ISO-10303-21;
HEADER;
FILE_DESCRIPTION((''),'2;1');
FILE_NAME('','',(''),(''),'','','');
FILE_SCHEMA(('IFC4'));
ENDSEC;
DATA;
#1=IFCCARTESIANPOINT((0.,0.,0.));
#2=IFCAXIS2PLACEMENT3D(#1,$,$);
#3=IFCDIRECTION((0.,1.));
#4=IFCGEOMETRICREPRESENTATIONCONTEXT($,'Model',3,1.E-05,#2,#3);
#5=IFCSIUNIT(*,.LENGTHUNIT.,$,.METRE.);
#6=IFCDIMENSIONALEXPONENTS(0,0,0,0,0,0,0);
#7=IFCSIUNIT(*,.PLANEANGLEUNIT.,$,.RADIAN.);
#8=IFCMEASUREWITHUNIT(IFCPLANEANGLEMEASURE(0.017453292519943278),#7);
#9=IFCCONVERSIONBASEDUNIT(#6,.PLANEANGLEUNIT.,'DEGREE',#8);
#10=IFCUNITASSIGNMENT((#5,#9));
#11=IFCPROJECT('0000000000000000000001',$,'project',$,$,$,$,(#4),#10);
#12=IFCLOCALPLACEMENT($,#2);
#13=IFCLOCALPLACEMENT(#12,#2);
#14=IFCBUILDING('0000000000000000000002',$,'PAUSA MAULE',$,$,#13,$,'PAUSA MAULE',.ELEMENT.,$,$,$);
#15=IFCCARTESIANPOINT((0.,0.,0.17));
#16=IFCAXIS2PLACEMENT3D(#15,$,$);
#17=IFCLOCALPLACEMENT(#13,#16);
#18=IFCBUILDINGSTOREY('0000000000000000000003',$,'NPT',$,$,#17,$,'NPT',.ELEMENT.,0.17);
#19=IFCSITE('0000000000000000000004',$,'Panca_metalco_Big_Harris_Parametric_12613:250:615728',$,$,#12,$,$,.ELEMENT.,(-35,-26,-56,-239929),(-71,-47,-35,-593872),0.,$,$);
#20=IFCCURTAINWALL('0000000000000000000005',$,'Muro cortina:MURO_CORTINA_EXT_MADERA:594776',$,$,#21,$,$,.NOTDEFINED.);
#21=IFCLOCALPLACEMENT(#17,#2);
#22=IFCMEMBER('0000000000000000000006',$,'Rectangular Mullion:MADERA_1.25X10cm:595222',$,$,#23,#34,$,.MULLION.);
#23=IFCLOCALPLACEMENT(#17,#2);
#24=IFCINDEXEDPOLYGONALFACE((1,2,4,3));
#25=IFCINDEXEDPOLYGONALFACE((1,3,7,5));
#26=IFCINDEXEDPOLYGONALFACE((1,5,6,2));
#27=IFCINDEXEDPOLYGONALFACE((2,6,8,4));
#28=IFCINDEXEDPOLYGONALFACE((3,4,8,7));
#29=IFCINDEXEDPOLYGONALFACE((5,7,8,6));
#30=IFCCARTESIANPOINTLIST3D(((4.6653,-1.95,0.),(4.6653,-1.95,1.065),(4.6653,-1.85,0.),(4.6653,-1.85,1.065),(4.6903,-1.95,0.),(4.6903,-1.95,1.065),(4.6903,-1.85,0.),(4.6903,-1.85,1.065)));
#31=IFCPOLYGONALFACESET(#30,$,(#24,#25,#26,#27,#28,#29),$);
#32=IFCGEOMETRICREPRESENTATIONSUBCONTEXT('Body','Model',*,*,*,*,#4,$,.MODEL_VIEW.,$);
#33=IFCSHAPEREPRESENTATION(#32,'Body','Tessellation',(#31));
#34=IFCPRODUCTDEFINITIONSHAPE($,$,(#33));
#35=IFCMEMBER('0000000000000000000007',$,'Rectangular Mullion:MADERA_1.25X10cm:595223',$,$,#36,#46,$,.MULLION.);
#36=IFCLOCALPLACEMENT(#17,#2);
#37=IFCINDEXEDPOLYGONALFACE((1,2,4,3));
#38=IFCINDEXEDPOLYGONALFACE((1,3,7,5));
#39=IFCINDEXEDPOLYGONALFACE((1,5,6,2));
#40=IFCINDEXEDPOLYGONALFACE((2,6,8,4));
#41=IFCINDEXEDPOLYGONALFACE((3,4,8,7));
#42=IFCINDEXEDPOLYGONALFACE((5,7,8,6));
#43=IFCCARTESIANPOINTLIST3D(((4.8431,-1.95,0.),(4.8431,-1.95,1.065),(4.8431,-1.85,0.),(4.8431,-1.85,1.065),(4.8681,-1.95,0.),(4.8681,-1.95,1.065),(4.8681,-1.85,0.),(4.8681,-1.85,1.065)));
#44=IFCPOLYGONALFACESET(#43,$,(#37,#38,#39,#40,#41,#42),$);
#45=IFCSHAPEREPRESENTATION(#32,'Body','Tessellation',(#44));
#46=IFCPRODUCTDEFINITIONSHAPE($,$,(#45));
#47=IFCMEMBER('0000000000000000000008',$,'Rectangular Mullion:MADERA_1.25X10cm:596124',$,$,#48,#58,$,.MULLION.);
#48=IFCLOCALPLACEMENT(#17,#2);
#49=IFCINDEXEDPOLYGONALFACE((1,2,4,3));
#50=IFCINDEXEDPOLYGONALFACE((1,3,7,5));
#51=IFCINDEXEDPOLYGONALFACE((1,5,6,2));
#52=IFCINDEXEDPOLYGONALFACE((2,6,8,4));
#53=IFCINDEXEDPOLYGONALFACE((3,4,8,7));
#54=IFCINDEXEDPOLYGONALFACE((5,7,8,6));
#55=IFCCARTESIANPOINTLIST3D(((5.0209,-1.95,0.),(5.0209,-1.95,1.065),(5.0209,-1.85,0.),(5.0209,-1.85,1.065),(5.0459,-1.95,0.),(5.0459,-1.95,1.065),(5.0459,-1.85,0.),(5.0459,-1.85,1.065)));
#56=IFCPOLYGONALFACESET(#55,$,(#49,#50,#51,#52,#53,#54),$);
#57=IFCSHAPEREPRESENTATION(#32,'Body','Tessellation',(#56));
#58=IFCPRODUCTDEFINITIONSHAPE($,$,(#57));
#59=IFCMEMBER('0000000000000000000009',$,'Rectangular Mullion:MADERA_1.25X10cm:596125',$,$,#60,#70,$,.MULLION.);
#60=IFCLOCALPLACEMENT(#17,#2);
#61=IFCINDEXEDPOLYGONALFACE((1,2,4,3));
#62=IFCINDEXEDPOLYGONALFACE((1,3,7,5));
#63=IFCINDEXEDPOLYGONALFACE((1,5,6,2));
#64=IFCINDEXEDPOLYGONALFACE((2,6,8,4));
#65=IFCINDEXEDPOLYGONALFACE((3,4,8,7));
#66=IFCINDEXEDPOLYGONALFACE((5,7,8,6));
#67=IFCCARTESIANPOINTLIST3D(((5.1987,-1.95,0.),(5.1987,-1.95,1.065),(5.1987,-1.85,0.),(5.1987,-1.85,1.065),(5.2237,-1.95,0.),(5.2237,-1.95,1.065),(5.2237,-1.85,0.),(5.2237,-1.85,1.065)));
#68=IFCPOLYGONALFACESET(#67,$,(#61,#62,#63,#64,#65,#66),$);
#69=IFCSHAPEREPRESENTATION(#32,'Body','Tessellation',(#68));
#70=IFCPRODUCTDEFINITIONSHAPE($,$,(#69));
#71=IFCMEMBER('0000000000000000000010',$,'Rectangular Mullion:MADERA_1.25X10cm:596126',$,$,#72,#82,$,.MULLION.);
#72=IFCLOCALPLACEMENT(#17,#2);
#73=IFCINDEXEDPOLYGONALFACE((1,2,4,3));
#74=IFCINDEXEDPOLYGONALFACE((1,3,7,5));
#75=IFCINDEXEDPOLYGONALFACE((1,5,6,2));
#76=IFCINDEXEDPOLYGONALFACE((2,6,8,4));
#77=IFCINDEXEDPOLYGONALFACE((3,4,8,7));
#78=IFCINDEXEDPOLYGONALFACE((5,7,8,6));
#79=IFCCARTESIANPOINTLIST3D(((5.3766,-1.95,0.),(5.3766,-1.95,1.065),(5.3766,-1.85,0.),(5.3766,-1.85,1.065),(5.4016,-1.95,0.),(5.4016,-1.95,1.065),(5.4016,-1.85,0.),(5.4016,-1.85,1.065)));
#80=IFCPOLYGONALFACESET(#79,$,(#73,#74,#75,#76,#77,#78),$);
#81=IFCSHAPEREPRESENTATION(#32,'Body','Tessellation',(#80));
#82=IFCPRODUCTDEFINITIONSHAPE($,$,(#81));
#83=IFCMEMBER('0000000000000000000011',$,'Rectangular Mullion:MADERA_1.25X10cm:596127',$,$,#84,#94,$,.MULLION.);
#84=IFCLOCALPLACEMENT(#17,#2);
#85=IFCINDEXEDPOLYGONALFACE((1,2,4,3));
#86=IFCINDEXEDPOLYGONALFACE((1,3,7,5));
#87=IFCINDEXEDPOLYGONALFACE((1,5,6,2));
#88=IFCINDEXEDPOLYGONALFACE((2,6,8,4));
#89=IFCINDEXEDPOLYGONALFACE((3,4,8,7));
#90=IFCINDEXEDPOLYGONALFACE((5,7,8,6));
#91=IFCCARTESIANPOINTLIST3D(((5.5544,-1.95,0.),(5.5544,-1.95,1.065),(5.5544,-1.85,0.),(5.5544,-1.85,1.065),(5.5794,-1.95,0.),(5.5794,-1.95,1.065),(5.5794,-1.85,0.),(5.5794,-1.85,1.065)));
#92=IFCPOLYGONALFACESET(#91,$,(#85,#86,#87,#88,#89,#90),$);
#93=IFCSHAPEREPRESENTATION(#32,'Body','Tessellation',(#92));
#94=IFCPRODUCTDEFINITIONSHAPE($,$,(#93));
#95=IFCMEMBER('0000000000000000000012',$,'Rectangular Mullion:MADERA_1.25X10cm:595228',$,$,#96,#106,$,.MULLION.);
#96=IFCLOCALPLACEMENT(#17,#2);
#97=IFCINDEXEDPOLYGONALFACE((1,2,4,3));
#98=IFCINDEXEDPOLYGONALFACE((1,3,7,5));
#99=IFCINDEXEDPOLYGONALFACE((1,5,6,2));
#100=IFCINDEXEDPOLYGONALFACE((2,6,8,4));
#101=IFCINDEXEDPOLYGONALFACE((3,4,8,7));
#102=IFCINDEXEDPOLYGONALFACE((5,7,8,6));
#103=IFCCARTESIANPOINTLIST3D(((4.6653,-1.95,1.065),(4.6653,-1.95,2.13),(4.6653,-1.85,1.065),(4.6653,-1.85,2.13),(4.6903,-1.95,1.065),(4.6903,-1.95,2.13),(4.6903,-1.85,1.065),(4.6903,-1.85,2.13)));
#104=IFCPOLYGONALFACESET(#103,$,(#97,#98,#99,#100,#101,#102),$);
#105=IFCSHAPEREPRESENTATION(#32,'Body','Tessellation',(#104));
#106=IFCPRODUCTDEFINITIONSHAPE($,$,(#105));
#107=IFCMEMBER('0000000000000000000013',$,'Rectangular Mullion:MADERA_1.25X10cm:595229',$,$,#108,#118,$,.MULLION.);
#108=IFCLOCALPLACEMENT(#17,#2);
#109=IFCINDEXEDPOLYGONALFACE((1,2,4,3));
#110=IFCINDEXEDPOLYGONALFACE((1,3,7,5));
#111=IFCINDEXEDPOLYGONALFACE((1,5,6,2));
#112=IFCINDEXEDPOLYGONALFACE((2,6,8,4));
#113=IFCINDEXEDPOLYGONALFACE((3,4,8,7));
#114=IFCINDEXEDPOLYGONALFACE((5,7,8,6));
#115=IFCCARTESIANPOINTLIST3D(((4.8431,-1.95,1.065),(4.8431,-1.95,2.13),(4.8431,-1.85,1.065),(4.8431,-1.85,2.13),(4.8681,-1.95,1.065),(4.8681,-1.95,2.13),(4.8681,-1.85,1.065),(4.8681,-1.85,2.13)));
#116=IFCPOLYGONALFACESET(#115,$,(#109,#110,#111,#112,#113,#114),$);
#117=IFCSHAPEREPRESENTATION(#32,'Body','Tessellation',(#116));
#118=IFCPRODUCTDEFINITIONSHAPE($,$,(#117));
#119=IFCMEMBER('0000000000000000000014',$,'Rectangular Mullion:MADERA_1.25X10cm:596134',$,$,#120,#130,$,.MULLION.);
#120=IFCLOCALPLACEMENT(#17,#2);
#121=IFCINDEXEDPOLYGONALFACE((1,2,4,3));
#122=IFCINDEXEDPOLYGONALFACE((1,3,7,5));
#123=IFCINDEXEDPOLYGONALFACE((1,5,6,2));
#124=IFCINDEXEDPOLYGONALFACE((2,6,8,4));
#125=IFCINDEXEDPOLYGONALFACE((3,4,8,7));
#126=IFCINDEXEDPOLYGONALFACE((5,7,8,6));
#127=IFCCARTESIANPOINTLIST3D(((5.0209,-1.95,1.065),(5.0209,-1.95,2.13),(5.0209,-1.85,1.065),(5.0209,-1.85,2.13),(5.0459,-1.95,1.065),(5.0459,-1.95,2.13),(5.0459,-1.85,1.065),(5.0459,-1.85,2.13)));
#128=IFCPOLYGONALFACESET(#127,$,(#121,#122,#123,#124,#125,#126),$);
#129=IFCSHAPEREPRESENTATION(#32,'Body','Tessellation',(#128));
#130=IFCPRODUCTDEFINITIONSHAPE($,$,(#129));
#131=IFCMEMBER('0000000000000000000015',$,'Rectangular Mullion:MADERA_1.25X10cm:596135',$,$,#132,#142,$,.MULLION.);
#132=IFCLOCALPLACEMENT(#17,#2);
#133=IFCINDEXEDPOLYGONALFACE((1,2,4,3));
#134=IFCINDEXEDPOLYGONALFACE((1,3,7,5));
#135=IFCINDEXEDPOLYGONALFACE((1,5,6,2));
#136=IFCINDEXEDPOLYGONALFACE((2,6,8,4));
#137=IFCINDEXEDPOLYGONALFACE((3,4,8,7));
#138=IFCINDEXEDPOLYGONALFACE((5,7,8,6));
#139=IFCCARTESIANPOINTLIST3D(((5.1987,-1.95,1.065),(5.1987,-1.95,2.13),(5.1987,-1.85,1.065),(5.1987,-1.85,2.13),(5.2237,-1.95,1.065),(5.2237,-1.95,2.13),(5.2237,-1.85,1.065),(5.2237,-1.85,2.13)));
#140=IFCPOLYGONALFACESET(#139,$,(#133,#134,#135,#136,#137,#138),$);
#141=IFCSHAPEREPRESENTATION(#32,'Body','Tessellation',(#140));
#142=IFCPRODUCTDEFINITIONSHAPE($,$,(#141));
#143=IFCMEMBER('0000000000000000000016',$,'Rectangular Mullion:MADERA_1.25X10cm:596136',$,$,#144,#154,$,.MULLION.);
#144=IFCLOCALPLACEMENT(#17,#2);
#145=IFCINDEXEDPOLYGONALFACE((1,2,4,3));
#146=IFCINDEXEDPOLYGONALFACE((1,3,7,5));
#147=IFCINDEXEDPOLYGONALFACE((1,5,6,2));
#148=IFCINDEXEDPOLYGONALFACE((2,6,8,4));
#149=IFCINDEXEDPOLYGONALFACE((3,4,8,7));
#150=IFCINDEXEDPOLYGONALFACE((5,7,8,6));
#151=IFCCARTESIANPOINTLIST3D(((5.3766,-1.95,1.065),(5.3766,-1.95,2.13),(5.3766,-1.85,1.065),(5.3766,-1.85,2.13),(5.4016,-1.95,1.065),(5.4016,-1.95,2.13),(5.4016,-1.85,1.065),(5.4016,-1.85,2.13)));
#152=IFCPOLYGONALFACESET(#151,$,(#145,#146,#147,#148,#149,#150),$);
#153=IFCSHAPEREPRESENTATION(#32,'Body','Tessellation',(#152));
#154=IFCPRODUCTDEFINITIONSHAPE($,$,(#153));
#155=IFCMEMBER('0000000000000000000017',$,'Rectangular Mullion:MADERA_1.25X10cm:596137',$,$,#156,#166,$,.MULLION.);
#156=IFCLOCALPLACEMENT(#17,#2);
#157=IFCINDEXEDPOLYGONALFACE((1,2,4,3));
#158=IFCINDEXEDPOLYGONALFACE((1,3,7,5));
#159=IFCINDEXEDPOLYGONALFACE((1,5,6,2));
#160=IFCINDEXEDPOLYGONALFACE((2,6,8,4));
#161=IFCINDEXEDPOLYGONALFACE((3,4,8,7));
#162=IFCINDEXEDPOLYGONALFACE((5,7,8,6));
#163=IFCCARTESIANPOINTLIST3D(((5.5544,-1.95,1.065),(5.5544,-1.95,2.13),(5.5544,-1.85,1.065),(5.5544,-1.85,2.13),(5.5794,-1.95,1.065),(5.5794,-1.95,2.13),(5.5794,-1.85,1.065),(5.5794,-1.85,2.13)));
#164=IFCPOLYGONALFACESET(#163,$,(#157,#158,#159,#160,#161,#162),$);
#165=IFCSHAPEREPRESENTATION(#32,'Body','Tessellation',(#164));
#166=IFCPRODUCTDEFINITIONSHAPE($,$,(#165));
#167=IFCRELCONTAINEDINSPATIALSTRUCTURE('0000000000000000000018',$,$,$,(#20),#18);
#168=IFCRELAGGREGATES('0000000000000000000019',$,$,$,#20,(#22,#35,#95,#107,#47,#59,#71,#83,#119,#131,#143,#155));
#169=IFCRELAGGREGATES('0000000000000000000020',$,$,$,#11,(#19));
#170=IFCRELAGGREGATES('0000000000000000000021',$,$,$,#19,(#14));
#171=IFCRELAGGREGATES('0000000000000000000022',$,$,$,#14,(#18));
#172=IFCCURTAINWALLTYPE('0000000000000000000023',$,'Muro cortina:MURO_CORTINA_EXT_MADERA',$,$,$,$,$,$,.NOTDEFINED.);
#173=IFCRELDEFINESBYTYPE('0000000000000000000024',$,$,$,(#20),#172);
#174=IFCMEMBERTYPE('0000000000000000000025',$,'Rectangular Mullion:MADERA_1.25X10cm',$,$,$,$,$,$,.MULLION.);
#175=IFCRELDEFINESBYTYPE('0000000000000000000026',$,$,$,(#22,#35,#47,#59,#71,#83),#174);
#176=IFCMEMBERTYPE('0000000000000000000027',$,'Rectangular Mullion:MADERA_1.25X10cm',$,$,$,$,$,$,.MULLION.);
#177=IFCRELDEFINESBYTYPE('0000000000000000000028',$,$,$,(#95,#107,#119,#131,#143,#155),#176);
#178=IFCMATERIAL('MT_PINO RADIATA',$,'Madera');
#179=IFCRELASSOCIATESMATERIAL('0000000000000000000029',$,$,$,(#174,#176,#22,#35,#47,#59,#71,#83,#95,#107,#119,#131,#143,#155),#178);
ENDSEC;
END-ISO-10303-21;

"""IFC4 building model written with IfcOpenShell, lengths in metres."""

from ifc_helpers import new_model, entity, si_unit, converted_unit, direction, frame, frame_2d, origin, place, context, subcontext, project, spatial, rectangle, extrude, source, transform, mapped, material, material_profile, profile_set, profile_usage, type_object, type_shapes, element, aggregate, save


model = new_model("IFC4")

# Units and contexts
model_context = context("Model", 3, precision=1e-05, world=origin(), true_north=direction((0.0, 1.0)))
body_context = subcontext(model_context, "Body", "Model", "MODEL_VIEW")
ifc_project = project(units=[si_unit("LENGTHUNIT", "METRE"), converted_unit("PLANEANGLEUNIT", "DEGREE", entity("IfcPlaneAngleMeasure", 0.017453292519943278), si_unit("PLANEANGLEUNIT", "RADIAN"), dimensions=[0, 0, 0, 0, 0, 0, 0])], contexts=[model_context])

# Site, building, storey
site_placement = place(None, origin())
site = spatial("IfcSite", under=ifc_project, at=site_placement, Name="Panca_metalco_Big_Harris_Parametric_12613:250:615728", CompositionType="ELEMENT", RefLatitude=(-35, -26, -56, -239929), RefLongitude=(-71, -47, -35, -593872), RefElevation=0.0)
building_placement = place(site_placement, origin())
building = spatial("IfcBuilding", under=site, at=building_placement, Name="PAUSA MAULE", LongName="PAUSA MAULE", CompositionType="ELEMENT")
storey_placement = place(building_placement, frame((0.0, 0.0, 0.17)))
storey = spatial("IfcBuildingStorey", under=building, at=storey_placement, Name="NPT", LongName="NPT", CompositionType="ELEMENT", Elevation=0.17)

# Curtain wall, members
curtain_wall_type = type_object("IfcCurtainWallType", Name="Muro cortina:MURO_CORTINA_EXT_MADERA", PredefinedType="NOTDEFINED")
curtain_wall_placement = place(storey_placement, frame((0.0, 0.0, -0.17)))
curtain_wall = element("IfcCurtainWall", 1, at=curtain_wall_placement, inside=storey, type_object=curtain_wall_type, Name="Muro cortina:MURO_CORTINA_EXT_MADERA:594776", PredefinedType="NOTDEFINED")
ifc_material = material(Name="MT_PINO RADIATA", Category="Madera")
ifc_material_profile = material_profile(ifc_material, rectangle(XDim=0.025, YDim=0.1, at=frame_2d((0.0, 0.0), x_axis=(1.0, 0.0))), Name="MADERA_1.25X10cm")
ifc_profile_set = profile_set([ifc_material_profile], Name="MADERA_1.25X10cm")
ifc_profile_usage = profile_usage(ifc_profile_set)
member_type_1 = type_object("IfcMemberType", Name="Rectangular Mullion:MADERA_1.25X10cm", PredefinedType="MULLION", material=ifc_profile_set)
shared_shape_1 = source(origin(), body_context, "Body", "SweptSolid", [
    extrude(rectangle(XDim=0.025, YDim=0.1, at=frame_2d((0.0, 0.0), x_axis=(1.0, 0.0))), frame((0.0, 0.0, -1.065), z_axis=(0.0, 0.0, 1.0), x_axis=(-1.0, 0.0, 0.0)), (0.0, 0.0, 1.0), 1.065),
])
type_shapes(member_type_1, [shared_shape_1])
member_1_placement = place(curtain_wall_placement, frame((4.6778, -1.9, 0.17), z_axis=(0.0, 0.0, -1.0), x_axis=(1.0, 0.0, 0.0)))
member_1 = element("IfcMember", 2, at=member_1_placement, type_object=member_type_1, material=ifc_profile_usage, Name="Rectangular Mullion:MADERA_1.25X10cm:595222", PredefinedType="MULLION", context=body_context, shape_type="MappedRepresentation", body=[
    mapped(shared_shape_1, transform((0.0, 0.0, 0.0), scale=1.0)),
])
member_2_placement = place(curtain_wall_placement, frame((4.8556, -1.9, 0.17), z_axis=(0.0, 0.0, -1.0), x_axis=(1.0, 0.0, 0.0)))
member_2 = element("IfcMember", 3, at=member_2_placement, type_object=member_type_1, material=ifc_profile_usage, Name="Rectangular Mullion:MADERA_1.25X10cm:595223", PredefinedType="MULLION", context=body_context, shape_type="MappedRepresentation", body=[
    mapped(shared_shape_1, transform((0.0, 0.0, 0.0), scale=1.0)),
])
member_3_placement = place(curtain_wall_placement, frame((5.0334, -1.9, 0.17), z_axis=(0.0, 0.0, -1.0), x_axis=(1.0, 0.0, 0.0)))
member_3 = element("IfcMember", 4, at=member_3_placement, type_object=member_type_1, material=ifc_profile_usage, Name="Rectangular Mullion:MADERA_1.25X10cm:596124", PredefinedType="MULLION", context=body_context, shape_type="MappedRepresentation", body=[
    mapped(shared_shape_1, transform((0.0, 0.0, 0.0), scale=1.0)),
])
member_4_placement = place(curtain_wall_placement, frame((5.2112, -1.9, 0.17), z_axis=(0.0, 0.0, -1.0), x_axis=(1.0, 0.0, 0.0)))
member_4 = element("IfcMember", 5, at=member_4_placement, type_object=member_type_1, material=ifc_profile_usage, Name="Rectangular Mullion:MADERA_1.25X10cm:596125", PredefinedType="MULLION", context=body_context, shape_type="MappedRepresentation", body=[
    mapped(shared_shape_1, transform((0.0, 0.0, 0.0), scale=1.0)),
])
member_5_placement = place(curtain_wall_placement, frame((5.3891, -1.9, 0.17), z_axis=(0.0, 0.0, -1.0), x_axis=(1.0, 0.0, 0.0)))
member_5 = element("IfcMember", 6, at=member_5_placement, type_object=member_type_1, material=ifc_profile_usage, Name="Rectangular Mullion:MADERA_1.25X10cm:596126", PredefinedType="MULLION", context=body_context, shape_type="MappedRepresentation", body=[
    mapped(shared_shape_1, transform((0.0, 0.0, 0.0), scale=1.0)),
])
member_6_placement = place(curtain_wall_placement, frame((5.5669, -1.9, 0.17), z_axis=(0.0, 0.0, -1.0), x_axis=(1.0, 0.0, 0.0)))
member_6 = element("IfcMember", 7, at=member_6_placement, type_object=member_type_1, material=ifc_profile_usage, Name="Rectangular Mullion:MADERA_1.25X10cm:596127", PredefinedType="MULLION", context=body_context, shape_type="MappedRepresentation", body=[
    mapped(shared_shape_1, transform((0.0, 0.0, 0.0), scale=1.0)),
])
member_type_2 = type_object("IfcMemberType", Name="Rectangular Mullion:MADERA_1.25X10cm", PredefinedType="MULLION", material=ifc_profile_set)
shared_shape_2 = source(origin(), body_context, "Body", "SweptSolid", [
    extrude(rectangle(XDim=0.025, YDim=0.1, at=frame_2d((0.0, 0.0), x_axis=(1.0, 0.0))), frame((0.0, 0.0, -1.065), z_axis=(0.0, 0.0, 1.0), x_axis=(-1.0, 0.0, 0.0)), (0.0, 0.0, 1.0), 1.065),
])
type_shapes(member_type_2, [shared_shape_2])
member_7_placement = place(curtain_wall_placement, frame((4.6778, -1.9, 1.235), z_axis=(0.0, 0.0, -1.0), x_axis=(1.0, 0.0, 0.0)))
member_7 = element("IfcMember", 8, at=member_7_placement, type_object=member_type_2, material=ifc_profile_usage, Name="Rectangular Mullion:MADERA_1.25X10cm:595228", PredefinedType="MULLION", context=body_context, shape_type="MappedRepresentation", body=[
    mapped(shared_shape_2, transform((0.0, 0.0, 0.0), scale=1.0)),
])
member_8_placement = place(curtain_wall_placement, frame((4.8556, -1.9, 1.235), z_axis=(0.0, 0.0, -1.0), x_axis=(1.0, 0.0, 0.0)))
member_8 = element("IfcMember", 9, at=member_8_placement, type_object=member_type_2, material=ifc_profile_usage, Name="Rectangular Mullion:MADERA_1.25X10cm:595229", PredefinedType="MULLION", context=body_context, shape_type="MappedRepresentation", body=[
    mapped(shared_shape_2, transform((0.0, 0.0, 0.0), scale=1.0)),
])
member_9_placement = place(curtain_wall_placement, frame((5.0334, -1.9, 1.235), z_axis=(0.0, 0.0, -1.0), x_axis=(1.0, 0.0, 0.0)))
member_9 = element("IfcMember", 10, at=member_9_placement, type_object=member_type_2, material=ifc_profile_usage, Name="Rectangular Mullion:MADERA_1.25X10cm:596134", PredefinedType="MULLION", context=body_context, shape_type="MappedRepresentation", body=[
    mapped(shared_shape_2, transform((0.0, 0.0, 0.0), scale=1.0)),
])
member_10_placement = place(curtain_wall_placement, frame((5.2112, -1.9, 1.235), z_axis=(0.0, 0.0, -1.0), x_axis=(1.0, 0.0, 0.0)))
member_10 = element("IfcMember", 11, at=member_10_placement, type_object=member_type_2, material=ifc_profile_usage, Name="Rectangular Mullion:MADERA_1.25X10cm:596135", PredefinedType="MULLION", context=body_context, shape_type="MappedRepresentation", body=[
    mapped(shared_shape_2, transform((0.0, 0.0, 0.0), scale=1.0)),
])
member_11_placement = place(curtain_wall_placement, frame((5.3891, -1.9, 1.235), z_axis=(0.0, 0.0, -1.0), x_axis=(1.0, 0.0, 0.0)))
member_11 = element("IfcMember", 12, at=member_11_placement, type_object=member_type_2, material=ifc_profile_usage, Name="Rectangular Mullion:MADERA_1.25X10cm:596136", PredefinedType="MULLION", context=body_context, shape_type="MappedRepresentation", body=[
    mapped(shared_shape_2, transform((0.0, 0.0, 0.0), scale=1.0)),
])
member_12_placement = place(curtain_wall_placement, frame((5.5669, -1.9, 1.235), z_axis=(0.0, 0.0, -1.0), x_axis=(1.0, 0.0, 0.0)))
member_12 = element("IfcMember", 13, at=member_12_placement, type_object=member_type_2, material=ifc_profile_usage, Name="Rectangular Mullion:MADERA_1.25X10cm:596137", PredefinedType="MULLION", context=body_context, shape_type="MappedRepresentation", body=[
    mapped(shared_shape_2, transform((0.0, 0.0, 0.0), scale=1.0)),
])
aggregate(curtain_wall, [member_1, member_2, member_7, member_8, member_3, member_4, member_5, member_6, member_9, member_10, member_11, member_12])

save(model, "model.ifc")
